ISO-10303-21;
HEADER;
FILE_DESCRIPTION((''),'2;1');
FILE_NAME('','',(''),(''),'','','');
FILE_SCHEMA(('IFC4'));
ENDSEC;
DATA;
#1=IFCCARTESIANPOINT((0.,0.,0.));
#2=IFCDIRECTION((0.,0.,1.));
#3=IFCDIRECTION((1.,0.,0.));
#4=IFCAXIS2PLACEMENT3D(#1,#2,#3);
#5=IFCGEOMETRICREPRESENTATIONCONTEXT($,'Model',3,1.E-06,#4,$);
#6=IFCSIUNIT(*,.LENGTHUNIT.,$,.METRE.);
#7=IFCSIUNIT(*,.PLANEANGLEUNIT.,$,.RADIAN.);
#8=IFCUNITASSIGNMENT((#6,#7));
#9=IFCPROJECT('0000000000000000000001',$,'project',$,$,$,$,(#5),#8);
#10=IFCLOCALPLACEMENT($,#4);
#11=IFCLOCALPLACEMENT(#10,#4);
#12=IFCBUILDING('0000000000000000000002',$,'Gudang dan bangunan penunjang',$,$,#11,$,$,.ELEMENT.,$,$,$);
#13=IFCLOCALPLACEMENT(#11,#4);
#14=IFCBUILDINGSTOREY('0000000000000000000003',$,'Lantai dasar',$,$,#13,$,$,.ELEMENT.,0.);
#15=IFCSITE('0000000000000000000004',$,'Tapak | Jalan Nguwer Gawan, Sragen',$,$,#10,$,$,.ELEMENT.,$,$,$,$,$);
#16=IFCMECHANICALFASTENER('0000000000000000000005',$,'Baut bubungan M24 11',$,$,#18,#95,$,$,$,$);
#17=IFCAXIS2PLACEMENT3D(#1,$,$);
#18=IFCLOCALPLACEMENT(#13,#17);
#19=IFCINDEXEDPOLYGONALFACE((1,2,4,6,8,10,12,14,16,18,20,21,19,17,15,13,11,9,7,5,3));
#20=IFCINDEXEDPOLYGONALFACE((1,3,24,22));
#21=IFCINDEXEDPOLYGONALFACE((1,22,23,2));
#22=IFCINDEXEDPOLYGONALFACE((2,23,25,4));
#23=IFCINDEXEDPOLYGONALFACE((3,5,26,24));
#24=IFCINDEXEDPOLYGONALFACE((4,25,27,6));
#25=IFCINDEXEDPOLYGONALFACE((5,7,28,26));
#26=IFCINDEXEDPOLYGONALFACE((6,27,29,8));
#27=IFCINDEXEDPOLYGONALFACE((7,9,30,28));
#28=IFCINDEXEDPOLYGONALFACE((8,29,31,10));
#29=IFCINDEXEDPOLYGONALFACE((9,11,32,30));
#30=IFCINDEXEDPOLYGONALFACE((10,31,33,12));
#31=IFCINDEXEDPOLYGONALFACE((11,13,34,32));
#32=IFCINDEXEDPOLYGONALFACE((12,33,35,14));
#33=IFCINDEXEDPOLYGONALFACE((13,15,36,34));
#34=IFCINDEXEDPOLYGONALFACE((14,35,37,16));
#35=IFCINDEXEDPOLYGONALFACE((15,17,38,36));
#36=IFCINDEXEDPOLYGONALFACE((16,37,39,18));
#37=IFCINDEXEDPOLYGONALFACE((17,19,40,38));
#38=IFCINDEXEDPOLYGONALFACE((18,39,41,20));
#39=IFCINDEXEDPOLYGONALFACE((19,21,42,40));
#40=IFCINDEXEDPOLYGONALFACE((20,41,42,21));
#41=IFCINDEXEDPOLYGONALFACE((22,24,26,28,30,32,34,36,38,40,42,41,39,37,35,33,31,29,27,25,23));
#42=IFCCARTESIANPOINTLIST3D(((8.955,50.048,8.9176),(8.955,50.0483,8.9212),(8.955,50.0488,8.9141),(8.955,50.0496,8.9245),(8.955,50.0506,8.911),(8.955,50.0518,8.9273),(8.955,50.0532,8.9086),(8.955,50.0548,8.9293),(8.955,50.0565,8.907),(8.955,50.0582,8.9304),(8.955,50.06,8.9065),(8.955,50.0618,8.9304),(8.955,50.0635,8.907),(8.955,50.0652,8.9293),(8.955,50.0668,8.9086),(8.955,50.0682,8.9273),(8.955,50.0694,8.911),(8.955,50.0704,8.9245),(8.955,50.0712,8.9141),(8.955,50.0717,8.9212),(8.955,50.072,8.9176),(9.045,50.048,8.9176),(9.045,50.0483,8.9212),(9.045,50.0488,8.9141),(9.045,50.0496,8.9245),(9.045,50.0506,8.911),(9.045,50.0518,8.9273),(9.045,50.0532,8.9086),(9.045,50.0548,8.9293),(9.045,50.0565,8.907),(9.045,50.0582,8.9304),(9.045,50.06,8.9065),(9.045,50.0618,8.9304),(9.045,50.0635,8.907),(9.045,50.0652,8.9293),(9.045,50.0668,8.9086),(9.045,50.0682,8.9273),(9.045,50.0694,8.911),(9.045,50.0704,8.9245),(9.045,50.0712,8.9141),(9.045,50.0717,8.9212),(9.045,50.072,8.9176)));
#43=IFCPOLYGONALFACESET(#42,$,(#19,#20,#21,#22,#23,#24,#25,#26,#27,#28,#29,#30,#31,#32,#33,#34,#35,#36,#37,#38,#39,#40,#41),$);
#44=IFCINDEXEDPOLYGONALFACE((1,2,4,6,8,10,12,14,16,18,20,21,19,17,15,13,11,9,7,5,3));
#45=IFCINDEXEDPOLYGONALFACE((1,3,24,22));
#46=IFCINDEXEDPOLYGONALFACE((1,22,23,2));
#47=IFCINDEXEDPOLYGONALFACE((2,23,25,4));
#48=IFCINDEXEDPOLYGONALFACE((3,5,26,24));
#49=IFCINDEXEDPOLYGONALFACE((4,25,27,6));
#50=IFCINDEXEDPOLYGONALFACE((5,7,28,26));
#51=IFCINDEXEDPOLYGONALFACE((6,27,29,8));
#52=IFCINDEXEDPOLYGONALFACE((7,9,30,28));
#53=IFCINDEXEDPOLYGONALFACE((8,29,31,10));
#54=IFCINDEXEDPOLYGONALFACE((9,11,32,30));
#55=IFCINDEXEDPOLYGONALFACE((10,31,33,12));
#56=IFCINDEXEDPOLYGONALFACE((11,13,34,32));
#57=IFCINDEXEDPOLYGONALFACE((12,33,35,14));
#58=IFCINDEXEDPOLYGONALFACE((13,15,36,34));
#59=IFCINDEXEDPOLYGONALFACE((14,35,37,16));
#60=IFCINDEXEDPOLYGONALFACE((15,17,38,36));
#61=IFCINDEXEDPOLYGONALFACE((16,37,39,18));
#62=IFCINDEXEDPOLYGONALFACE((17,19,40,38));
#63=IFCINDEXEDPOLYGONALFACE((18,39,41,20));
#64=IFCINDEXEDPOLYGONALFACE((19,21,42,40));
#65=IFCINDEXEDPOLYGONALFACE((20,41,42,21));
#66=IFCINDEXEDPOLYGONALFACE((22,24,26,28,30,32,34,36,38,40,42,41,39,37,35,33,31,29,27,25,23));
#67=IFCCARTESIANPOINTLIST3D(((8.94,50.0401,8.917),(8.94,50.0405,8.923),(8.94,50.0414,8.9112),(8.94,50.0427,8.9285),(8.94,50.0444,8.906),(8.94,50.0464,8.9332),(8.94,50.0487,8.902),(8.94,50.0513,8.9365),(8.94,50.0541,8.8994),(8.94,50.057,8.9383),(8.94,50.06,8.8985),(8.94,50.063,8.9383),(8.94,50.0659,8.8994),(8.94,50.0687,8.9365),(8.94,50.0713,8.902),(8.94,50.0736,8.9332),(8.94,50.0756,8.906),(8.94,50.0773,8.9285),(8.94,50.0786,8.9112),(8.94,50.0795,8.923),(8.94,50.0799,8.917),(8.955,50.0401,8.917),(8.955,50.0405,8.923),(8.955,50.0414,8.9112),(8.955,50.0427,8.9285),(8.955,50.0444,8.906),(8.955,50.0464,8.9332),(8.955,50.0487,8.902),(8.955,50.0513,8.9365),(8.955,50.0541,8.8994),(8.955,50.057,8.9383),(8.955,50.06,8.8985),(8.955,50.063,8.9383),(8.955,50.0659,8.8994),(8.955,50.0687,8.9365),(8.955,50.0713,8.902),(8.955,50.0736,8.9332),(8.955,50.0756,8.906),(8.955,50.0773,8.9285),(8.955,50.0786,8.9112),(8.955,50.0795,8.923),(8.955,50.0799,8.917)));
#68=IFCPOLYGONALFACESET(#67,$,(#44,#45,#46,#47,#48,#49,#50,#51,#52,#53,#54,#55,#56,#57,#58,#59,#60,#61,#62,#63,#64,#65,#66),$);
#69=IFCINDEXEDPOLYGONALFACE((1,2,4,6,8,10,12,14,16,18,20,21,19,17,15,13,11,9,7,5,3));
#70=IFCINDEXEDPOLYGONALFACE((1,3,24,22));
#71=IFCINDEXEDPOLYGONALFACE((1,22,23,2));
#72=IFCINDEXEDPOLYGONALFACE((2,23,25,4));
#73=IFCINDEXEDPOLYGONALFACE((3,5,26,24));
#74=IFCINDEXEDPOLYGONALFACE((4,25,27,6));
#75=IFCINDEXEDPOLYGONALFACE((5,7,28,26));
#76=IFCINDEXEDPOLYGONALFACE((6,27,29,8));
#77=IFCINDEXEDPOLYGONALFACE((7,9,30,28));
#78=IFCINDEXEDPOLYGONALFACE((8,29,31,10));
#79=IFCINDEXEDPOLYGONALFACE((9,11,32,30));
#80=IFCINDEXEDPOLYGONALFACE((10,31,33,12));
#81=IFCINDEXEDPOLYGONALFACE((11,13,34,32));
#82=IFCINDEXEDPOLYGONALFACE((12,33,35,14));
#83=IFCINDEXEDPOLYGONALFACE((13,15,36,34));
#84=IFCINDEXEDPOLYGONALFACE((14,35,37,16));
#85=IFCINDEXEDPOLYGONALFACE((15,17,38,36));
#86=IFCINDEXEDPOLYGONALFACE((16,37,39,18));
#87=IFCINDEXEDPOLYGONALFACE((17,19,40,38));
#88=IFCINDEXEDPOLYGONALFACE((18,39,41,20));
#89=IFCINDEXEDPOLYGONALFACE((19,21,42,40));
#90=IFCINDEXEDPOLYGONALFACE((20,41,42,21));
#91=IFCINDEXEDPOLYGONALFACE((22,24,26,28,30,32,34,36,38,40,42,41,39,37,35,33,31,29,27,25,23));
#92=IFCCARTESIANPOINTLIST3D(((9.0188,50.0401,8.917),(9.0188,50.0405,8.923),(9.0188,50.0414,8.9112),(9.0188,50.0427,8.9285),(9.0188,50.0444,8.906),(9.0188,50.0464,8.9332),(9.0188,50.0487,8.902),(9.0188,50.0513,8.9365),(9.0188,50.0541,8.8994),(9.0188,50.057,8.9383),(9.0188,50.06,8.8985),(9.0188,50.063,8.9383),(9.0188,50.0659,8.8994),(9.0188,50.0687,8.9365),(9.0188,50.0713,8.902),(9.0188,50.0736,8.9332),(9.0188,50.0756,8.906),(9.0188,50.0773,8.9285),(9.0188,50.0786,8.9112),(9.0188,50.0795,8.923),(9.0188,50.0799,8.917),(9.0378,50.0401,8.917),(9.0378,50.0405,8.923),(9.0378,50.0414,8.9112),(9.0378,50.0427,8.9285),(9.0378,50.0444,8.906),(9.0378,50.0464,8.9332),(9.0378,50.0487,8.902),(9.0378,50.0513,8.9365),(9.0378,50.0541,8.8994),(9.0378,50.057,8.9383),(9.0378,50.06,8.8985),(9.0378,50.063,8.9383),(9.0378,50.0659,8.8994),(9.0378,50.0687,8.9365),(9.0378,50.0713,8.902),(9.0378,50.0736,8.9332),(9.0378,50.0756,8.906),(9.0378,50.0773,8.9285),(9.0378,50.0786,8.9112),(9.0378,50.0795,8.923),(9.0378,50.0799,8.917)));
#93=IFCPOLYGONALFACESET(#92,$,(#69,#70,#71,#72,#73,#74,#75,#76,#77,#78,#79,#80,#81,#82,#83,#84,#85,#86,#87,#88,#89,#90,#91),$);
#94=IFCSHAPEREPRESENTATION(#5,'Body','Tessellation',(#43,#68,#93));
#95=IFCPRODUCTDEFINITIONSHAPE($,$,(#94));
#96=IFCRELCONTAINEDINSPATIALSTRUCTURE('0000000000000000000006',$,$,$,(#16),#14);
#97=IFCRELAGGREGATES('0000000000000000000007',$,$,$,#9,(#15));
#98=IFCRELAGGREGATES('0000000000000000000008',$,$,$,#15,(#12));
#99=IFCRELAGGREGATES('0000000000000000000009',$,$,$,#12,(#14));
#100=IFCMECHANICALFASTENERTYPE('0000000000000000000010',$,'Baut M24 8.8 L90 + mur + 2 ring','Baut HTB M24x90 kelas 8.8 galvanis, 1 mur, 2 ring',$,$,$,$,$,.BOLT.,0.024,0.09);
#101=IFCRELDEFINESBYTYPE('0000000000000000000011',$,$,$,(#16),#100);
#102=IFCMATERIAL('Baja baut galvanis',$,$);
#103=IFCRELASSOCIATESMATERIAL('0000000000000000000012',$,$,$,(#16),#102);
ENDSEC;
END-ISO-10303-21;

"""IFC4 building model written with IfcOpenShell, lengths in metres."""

from ifc_helpers import new_model, si_unit, frame, origin_with_axes, place, context, project, spatial, circle, extrude, source, transform, mapped, material, type_object, type_shapes, element, save


model = new_model("IFC4")

# Units and contexts
model_context = context("Model", 3, precision=1e-06, world=origin_with_axes())
ifc_project = project(units=[si_unit("LENGTHUNIT", "METRE"), si_unit("PLANEANGLEUNIT", "RADIAN")], contexts=[model_context])

# Site, building, storey
site_placement = place(None, origin_with_axes())
site = spatial("IfcSite", under=ifc_project, at=site_placement, Name="Tapak | Jalan Nguwer Gawan, Sragen", CompositionType="ELEMENT")
building_placement = place(site_placement, origin_with_axes())
building = spatial("IfcBuilding", under=site, at=building_placement, Name="Gudang dan bangunan penunjang", CompositionType="ELEMENT")
storey_placement = place(building_placement, origin_with_axes())
storey = spatial("IfcBuildingStorey", under=building, at=storey_placement, Name="Lantai dasar", CompositionType="ELEMENT", Elevation=0.0)

# Shared definitions
placement = place(None, origin_with_axes())

# Mechanical fastener
ifc_material_1 = material(Name="Baja baut galvanis")
mechanical_fastener_type_1 = type_object("IfcMechanicalFastenerType", Name="Baut M24 8.8 L90 + mur + 2 ring", Description="Baut HTB M24x90 kelas 8.8 galvanis, 1 mur, 2 ring", NominalDiameter=0.024, NominalLength=0.09, PredefinedType="BOLT")
shared_shape_1 = source(origin_with_axes(), model_context, "Body", "SweptSolid", [
    extrude(circle(Radius=0.012), origin_with_axes(), (0.0, 0.0, 1.0), 0.09),
    extrude(circle(Radius=0.02), frame((0.0, 0.0, -0.015), z_axis=(0.0, 0.0, 1.0), x_axis=(1.0, 0.0, 0.0)), (0.0, 0.0, 1.0), 0.015),
    extrude(circle(Radius=0.02), frame((0.0, 0.0, 0.0638), z_axis=(0.0, 0.0, 1.0), x_axis=(1.0, 0.0, 0.0)), (0.0, 0.0, 1.0), 0.019),
])
type_shapes(mechanical_fastener_type_1, [shared_shape_1])
element("IfcMechanicalFastener", 1, at=placement, inside=storey, type_object=mechanical_fastener_type_1, material=ifc_material_1, Name="Baut bubungan M24 11", context=model_context, shape_type="MappedRepresentation", body=[
    mapped(shared_shape_1, transform((8.955, 50.06, 8.9185), x_axis=(0.0, 0.0, -1.0), y_axis=(0.0, 1.0, 0.0), z_axis=(1.0, 0.0, 0.0), scale=1.0)),
])

save(model, "model.ifc")
